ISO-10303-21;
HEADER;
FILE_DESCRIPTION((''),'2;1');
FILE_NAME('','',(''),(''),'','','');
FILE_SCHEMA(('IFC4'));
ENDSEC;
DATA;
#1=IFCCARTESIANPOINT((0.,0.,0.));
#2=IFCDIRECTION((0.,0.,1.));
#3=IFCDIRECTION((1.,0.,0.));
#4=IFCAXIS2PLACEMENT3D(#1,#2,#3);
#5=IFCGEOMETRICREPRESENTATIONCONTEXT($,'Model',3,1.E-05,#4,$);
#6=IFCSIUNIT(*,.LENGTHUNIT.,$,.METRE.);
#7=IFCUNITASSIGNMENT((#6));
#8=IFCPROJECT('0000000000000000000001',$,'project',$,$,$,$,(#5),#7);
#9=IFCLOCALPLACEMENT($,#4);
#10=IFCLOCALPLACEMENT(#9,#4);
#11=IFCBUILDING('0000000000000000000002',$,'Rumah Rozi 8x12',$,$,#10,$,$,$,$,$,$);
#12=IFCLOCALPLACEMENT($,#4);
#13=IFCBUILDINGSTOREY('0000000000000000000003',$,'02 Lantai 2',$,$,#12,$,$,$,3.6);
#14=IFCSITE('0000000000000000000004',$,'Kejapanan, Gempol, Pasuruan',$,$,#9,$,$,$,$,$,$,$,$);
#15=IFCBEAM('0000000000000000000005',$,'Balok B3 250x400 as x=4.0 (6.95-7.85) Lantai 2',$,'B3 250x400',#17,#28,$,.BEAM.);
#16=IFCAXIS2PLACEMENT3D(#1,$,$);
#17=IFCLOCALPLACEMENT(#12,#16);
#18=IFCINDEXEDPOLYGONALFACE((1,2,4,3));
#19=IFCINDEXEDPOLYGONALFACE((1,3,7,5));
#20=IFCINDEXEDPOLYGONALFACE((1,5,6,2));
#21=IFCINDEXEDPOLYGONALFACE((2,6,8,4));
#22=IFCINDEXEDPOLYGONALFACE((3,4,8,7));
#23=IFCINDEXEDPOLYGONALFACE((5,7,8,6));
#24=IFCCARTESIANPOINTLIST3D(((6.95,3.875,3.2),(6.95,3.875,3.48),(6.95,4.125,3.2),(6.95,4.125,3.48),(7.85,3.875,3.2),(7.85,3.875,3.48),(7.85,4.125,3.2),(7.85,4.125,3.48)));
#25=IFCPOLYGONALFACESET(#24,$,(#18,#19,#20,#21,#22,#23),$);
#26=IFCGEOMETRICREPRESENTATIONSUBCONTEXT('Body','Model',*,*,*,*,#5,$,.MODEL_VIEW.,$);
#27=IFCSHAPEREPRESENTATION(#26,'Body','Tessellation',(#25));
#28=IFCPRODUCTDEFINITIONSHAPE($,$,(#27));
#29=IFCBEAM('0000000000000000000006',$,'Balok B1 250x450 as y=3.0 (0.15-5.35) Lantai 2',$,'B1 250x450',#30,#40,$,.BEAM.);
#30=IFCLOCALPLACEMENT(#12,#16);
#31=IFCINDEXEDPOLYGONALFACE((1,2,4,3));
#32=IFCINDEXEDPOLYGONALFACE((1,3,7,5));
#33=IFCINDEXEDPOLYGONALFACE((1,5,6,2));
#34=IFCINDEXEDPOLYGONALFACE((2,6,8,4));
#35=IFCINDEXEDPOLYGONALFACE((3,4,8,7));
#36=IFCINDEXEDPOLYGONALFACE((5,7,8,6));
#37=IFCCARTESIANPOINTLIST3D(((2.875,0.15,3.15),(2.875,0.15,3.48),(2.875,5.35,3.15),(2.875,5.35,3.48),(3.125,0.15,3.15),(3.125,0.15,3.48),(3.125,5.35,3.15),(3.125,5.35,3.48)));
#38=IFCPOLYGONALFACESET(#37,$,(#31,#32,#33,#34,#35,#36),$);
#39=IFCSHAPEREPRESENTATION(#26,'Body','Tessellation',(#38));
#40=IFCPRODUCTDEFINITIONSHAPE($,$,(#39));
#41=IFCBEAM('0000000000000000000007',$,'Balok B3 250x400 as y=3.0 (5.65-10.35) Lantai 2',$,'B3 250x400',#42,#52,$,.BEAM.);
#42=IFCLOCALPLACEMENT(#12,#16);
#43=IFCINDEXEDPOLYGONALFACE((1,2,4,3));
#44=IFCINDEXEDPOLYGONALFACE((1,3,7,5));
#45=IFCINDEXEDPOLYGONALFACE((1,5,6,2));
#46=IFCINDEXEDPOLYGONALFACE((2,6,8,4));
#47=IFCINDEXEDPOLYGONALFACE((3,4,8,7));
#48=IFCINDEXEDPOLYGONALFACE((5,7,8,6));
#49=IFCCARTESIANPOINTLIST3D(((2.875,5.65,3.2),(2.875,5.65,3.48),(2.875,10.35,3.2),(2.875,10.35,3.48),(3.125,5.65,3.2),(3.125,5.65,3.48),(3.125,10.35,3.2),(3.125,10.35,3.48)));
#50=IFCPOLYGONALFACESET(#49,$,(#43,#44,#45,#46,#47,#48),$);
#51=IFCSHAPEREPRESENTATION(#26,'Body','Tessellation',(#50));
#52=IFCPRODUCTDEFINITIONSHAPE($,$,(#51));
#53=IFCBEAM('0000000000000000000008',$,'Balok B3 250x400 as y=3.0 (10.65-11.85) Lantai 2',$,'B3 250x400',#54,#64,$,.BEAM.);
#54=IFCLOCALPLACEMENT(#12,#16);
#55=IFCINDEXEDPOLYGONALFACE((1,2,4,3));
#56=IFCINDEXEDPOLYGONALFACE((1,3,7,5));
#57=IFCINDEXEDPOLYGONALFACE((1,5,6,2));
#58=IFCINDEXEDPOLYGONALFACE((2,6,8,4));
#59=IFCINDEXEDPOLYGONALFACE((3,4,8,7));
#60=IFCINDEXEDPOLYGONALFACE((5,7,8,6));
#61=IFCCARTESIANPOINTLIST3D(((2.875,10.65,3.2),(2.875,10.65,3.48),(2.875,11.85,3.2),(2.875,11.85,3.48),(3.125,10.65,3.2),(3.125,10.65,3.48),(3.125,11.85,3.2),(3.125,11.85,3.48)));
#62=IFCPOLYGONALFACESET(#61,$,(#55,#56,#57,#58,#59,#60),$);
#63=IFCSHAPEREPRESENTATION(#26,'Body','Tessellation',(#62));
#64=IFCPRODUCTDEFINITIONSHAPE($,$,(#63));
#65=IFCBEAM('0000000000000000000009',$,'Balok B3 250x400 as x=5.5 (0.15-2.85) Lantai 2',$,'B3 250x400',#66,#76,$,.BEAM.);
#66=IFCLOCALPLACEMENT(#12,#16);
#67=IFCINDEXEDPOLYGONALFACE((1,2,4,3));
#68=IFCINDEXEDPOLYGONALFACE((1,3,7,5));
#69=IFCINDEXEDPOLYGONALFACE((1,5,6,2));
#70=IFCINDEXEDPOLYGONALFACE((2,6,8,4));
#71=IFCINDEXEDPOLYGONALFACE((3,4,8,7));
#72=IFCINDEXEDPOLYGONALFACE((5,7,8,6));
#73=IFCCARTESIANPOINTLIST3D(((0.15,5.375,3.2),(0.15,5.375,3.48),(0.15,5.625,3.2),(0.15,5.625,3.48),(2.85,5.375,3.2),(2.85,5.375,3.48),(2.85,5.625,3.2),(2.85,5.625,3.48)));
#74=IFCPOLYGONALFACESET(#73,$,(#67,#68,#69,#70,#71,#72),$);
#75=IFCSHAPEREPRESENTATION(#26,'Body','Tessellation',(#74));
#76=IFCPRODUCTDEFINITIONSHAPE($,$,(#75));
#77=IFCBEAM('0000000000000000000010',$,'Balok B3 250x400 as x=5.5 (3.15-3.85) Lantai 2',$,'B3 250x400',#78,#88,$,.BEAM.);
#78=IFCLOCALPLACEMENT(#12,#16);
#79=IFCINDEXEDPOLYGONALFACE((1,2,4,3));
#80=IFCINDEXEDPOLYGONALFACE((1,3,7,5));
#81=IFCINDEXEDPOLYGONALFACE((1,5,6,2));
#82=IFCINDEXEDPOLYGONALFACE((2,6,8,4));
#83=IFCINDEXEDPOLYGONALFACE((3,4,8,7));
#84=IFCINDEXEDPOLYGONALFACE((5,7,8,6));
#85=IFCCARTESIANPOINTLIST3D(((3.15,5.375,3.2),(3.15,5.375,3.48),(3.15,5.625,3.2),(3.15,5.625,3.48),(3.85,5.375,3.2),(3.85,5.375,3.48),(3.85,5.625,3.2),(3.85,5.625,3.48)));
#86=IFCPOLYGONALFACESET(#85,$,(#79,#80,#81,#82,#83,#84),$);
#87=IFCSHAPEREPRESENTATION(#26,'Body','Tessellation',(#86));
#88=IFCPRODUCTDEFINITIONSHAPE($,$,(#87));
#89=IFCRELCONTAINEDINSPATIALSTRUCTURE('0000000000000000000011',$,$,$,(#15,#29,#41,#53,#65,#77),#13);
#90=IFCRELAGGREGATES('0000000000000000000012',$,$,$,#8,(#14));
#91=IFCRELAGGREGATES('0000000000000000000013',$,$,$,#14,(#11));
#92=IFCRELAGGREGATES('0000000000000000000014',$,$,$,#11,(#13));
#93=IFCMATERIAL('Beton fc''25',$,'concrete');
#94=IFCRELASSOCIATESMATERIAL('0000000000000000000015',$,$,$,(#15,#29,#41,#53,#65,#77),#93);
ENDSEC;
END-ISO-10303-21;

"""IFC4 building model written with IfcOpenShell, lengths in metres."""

from ifc_helpers import new_model, si_unit, frame, origin_with_axes, place, context, subcontext, project, spatial, line, indexed_curve, outline, extrude, material, element, save


model = new_model("IFC4")

# Units and contexts
model_context = context("Model", 3, precision=1e-05, world=origin_with_axes())
body_context = subcontext(model_context, "Body", "Model", "MODEL_VIEW")
ifc_project = project(units=[si_unit("LENGTHUNIT", "METRE")], contexts=[model_context])

# Site, building, storey
site_placement = place(None, origin_with_axes())
site = spatial("IfcSite", under=ifc_project, at=site_placement, Name="Kejapanan, Gempol, Pasuruan")
building_placement = place(site_placement, origin_with_axes())
building = spatial("IfcBuilding", under=site, at=building_placement, Name="Rumah Rozi 8x12")
storey_placement = place(None, origin_with_axes())
storey = spatial("IfcBuildingStorey", under=building, at=storey_placement, Name="02 Lantai 2", Elevation=3.6)

# Beams
ifc_material = material(Name="Beton fc'25", Category="concrete")
beam_1_placement = place(storey_placement, origin_with_axes())
element("IfcBeam", 1, at=beam_1_placement, inside=storey, material=ifc_material, Name="Balok B3 250x400 as x=4.0 (6.95-7.85) Lantai 2", ObjectType="B3 250x400", PredefinedType="BEAM", context=body_context, shape_type="SweptSolid", body=[
    extrude(outline(indexed_curve([(6.95, 3.875), (7.85, 3.875), (7.85, 4.125), (6.95, 4.125)], segments=[line(1, 2, 3, 4, 1)])), frame((0.0, 0.0, 3.2), z_axis=(0.0, 0.0, 1.0), x_axis=(1.0, 0.0, 0.0)), (0.0, 0.0, 1.0), 0.28),
])
beam_2_placement = place(storey_placement, origin_with_axes())
element("IfcBeam", 2, at=beam_2_placement, inside=storey, material=ifc_material, Name="Balok B1 250x450 as y=3.0 (0.15-5.35) Lantai 2", ObjectType="B1 250x450", PredefinedType="BEAM", context=body_context, shape_type="SweptSolid", body=[
    extrude(outline(indexed_curve([(2.875, 0.15), (3.125, 0.15), (3.125, 5.35), (2.875, 5.35)], segments=[line(1, 2, 3, 4, 1)])), frame((0.0, 0.0, 3.15), z_axis=(0.0, 0.0, 1.0), x_axis=(1.0, 0.0, 0.0)), (0.0, 0.0, 1.0), 0.33),
])
beam_3_placement = place(storey_placement, origin_with_axes())
element("IfcBeam", 3, at=beam_3_placement, inside=storey, material=ifc_material, Name="Balok B3 250x400 as y=3.0 (5.65-10.35) Lantai 2", ObjectType="B3 250x400", PredefinedType="BEAM", context=body_context, shape_type="SweptSolid", body=[
    extrude(outline(indexed_curve([(2.875, 5.65), (3.125, 5.65), (3.125, 10.35), (2.875, 10.35)], segments=[line(1, 2, 3, 4, 1)])), frame((0.0, 0.0, 3.2), z_axis=(0.0, 0.0, 1.0), x_axis=(1.0, 0.0, 0.0)), (0.0, 0.0, 1.0), 0.28),
])
beam_4_placement = place(storey_placement, origin_with_axes())
element("IfcBeam", 4, at=beam_4_placement, inside=storey, material=ifc_material, Name="Balok B3 250x400 as y=3.0 (10.65-11.85) Lantai 2", ObjectType="B3 250x400", PredefinedType="BEAM", context=body_context, shape_type="SweptSolid", body=[
    extrude(outline(indexed_curve([(2.875, 10.65), (3.125, 10.65), (3.125, 11.85), (2.875, 11.85)], segments=[line(1, 2, 3, 4, 1)])), frame((0.0, 0.0, 3.2), z_axis=(0.0, 0.0, 1.0), x_axis=(1.0, 0.0, 0.0)), (0.0, 0.0, 1.0), 0.28),
])
beam_5_placement = place(storey_placement, origin_with_axes())
element("IfcBeam", 5, at=beam_5_placement, inside=storey, material=ifc_material, Name="Balok B3 250x400 as x=5.5 (0.15-2.85) Lantai 2", ObjectType="B3 250x400", PredefinedType="BEAM", context=body_context, shape_type="SweptSolid", body=[
    extrude(outline(indexed_curve([(0.15, 5.375), (2.85, 5.375), (2.85, 5.625), (0.15, 5.625)], segments=[line(1, 2, 3, 4, 1)])), frame((0.0, 0.0, 3.2), z_axis=(0.0, 0.0, 1.0), x_axis=(1.0, 0.0, 0.0)), (0.0, 0.0, 1.0), 0.28),
])
beam_6_placement = place(storey_placement, origin_with_axes())
element("IfcBeam", 6, at=beam_6_placement, inside=storey, material=ifc_material, Name="Balok B3 250x400 as x=5.5 (3.15-3.85) Lantai 2", ObjectType="B3 250x400", PredefinedType="BEAM", context=body_context, shape_type="SweptSolid", body=[
    extrude(outline(indexed_curve([(3.15, 5.375), (3.85, 5.375), (3.85, 5.625), (3.15, 5.625)], segments=[line(1, 2, 3, 4, 1)])), frame((0.0, 0.0, 3.2), z_axis=(0.0, 0.0, 1.0), x_axis=(1.0, 0.0, 0.0)), (0.0, 0.0, 1.0), 0.28),
])

save(model, "model.ifc")
